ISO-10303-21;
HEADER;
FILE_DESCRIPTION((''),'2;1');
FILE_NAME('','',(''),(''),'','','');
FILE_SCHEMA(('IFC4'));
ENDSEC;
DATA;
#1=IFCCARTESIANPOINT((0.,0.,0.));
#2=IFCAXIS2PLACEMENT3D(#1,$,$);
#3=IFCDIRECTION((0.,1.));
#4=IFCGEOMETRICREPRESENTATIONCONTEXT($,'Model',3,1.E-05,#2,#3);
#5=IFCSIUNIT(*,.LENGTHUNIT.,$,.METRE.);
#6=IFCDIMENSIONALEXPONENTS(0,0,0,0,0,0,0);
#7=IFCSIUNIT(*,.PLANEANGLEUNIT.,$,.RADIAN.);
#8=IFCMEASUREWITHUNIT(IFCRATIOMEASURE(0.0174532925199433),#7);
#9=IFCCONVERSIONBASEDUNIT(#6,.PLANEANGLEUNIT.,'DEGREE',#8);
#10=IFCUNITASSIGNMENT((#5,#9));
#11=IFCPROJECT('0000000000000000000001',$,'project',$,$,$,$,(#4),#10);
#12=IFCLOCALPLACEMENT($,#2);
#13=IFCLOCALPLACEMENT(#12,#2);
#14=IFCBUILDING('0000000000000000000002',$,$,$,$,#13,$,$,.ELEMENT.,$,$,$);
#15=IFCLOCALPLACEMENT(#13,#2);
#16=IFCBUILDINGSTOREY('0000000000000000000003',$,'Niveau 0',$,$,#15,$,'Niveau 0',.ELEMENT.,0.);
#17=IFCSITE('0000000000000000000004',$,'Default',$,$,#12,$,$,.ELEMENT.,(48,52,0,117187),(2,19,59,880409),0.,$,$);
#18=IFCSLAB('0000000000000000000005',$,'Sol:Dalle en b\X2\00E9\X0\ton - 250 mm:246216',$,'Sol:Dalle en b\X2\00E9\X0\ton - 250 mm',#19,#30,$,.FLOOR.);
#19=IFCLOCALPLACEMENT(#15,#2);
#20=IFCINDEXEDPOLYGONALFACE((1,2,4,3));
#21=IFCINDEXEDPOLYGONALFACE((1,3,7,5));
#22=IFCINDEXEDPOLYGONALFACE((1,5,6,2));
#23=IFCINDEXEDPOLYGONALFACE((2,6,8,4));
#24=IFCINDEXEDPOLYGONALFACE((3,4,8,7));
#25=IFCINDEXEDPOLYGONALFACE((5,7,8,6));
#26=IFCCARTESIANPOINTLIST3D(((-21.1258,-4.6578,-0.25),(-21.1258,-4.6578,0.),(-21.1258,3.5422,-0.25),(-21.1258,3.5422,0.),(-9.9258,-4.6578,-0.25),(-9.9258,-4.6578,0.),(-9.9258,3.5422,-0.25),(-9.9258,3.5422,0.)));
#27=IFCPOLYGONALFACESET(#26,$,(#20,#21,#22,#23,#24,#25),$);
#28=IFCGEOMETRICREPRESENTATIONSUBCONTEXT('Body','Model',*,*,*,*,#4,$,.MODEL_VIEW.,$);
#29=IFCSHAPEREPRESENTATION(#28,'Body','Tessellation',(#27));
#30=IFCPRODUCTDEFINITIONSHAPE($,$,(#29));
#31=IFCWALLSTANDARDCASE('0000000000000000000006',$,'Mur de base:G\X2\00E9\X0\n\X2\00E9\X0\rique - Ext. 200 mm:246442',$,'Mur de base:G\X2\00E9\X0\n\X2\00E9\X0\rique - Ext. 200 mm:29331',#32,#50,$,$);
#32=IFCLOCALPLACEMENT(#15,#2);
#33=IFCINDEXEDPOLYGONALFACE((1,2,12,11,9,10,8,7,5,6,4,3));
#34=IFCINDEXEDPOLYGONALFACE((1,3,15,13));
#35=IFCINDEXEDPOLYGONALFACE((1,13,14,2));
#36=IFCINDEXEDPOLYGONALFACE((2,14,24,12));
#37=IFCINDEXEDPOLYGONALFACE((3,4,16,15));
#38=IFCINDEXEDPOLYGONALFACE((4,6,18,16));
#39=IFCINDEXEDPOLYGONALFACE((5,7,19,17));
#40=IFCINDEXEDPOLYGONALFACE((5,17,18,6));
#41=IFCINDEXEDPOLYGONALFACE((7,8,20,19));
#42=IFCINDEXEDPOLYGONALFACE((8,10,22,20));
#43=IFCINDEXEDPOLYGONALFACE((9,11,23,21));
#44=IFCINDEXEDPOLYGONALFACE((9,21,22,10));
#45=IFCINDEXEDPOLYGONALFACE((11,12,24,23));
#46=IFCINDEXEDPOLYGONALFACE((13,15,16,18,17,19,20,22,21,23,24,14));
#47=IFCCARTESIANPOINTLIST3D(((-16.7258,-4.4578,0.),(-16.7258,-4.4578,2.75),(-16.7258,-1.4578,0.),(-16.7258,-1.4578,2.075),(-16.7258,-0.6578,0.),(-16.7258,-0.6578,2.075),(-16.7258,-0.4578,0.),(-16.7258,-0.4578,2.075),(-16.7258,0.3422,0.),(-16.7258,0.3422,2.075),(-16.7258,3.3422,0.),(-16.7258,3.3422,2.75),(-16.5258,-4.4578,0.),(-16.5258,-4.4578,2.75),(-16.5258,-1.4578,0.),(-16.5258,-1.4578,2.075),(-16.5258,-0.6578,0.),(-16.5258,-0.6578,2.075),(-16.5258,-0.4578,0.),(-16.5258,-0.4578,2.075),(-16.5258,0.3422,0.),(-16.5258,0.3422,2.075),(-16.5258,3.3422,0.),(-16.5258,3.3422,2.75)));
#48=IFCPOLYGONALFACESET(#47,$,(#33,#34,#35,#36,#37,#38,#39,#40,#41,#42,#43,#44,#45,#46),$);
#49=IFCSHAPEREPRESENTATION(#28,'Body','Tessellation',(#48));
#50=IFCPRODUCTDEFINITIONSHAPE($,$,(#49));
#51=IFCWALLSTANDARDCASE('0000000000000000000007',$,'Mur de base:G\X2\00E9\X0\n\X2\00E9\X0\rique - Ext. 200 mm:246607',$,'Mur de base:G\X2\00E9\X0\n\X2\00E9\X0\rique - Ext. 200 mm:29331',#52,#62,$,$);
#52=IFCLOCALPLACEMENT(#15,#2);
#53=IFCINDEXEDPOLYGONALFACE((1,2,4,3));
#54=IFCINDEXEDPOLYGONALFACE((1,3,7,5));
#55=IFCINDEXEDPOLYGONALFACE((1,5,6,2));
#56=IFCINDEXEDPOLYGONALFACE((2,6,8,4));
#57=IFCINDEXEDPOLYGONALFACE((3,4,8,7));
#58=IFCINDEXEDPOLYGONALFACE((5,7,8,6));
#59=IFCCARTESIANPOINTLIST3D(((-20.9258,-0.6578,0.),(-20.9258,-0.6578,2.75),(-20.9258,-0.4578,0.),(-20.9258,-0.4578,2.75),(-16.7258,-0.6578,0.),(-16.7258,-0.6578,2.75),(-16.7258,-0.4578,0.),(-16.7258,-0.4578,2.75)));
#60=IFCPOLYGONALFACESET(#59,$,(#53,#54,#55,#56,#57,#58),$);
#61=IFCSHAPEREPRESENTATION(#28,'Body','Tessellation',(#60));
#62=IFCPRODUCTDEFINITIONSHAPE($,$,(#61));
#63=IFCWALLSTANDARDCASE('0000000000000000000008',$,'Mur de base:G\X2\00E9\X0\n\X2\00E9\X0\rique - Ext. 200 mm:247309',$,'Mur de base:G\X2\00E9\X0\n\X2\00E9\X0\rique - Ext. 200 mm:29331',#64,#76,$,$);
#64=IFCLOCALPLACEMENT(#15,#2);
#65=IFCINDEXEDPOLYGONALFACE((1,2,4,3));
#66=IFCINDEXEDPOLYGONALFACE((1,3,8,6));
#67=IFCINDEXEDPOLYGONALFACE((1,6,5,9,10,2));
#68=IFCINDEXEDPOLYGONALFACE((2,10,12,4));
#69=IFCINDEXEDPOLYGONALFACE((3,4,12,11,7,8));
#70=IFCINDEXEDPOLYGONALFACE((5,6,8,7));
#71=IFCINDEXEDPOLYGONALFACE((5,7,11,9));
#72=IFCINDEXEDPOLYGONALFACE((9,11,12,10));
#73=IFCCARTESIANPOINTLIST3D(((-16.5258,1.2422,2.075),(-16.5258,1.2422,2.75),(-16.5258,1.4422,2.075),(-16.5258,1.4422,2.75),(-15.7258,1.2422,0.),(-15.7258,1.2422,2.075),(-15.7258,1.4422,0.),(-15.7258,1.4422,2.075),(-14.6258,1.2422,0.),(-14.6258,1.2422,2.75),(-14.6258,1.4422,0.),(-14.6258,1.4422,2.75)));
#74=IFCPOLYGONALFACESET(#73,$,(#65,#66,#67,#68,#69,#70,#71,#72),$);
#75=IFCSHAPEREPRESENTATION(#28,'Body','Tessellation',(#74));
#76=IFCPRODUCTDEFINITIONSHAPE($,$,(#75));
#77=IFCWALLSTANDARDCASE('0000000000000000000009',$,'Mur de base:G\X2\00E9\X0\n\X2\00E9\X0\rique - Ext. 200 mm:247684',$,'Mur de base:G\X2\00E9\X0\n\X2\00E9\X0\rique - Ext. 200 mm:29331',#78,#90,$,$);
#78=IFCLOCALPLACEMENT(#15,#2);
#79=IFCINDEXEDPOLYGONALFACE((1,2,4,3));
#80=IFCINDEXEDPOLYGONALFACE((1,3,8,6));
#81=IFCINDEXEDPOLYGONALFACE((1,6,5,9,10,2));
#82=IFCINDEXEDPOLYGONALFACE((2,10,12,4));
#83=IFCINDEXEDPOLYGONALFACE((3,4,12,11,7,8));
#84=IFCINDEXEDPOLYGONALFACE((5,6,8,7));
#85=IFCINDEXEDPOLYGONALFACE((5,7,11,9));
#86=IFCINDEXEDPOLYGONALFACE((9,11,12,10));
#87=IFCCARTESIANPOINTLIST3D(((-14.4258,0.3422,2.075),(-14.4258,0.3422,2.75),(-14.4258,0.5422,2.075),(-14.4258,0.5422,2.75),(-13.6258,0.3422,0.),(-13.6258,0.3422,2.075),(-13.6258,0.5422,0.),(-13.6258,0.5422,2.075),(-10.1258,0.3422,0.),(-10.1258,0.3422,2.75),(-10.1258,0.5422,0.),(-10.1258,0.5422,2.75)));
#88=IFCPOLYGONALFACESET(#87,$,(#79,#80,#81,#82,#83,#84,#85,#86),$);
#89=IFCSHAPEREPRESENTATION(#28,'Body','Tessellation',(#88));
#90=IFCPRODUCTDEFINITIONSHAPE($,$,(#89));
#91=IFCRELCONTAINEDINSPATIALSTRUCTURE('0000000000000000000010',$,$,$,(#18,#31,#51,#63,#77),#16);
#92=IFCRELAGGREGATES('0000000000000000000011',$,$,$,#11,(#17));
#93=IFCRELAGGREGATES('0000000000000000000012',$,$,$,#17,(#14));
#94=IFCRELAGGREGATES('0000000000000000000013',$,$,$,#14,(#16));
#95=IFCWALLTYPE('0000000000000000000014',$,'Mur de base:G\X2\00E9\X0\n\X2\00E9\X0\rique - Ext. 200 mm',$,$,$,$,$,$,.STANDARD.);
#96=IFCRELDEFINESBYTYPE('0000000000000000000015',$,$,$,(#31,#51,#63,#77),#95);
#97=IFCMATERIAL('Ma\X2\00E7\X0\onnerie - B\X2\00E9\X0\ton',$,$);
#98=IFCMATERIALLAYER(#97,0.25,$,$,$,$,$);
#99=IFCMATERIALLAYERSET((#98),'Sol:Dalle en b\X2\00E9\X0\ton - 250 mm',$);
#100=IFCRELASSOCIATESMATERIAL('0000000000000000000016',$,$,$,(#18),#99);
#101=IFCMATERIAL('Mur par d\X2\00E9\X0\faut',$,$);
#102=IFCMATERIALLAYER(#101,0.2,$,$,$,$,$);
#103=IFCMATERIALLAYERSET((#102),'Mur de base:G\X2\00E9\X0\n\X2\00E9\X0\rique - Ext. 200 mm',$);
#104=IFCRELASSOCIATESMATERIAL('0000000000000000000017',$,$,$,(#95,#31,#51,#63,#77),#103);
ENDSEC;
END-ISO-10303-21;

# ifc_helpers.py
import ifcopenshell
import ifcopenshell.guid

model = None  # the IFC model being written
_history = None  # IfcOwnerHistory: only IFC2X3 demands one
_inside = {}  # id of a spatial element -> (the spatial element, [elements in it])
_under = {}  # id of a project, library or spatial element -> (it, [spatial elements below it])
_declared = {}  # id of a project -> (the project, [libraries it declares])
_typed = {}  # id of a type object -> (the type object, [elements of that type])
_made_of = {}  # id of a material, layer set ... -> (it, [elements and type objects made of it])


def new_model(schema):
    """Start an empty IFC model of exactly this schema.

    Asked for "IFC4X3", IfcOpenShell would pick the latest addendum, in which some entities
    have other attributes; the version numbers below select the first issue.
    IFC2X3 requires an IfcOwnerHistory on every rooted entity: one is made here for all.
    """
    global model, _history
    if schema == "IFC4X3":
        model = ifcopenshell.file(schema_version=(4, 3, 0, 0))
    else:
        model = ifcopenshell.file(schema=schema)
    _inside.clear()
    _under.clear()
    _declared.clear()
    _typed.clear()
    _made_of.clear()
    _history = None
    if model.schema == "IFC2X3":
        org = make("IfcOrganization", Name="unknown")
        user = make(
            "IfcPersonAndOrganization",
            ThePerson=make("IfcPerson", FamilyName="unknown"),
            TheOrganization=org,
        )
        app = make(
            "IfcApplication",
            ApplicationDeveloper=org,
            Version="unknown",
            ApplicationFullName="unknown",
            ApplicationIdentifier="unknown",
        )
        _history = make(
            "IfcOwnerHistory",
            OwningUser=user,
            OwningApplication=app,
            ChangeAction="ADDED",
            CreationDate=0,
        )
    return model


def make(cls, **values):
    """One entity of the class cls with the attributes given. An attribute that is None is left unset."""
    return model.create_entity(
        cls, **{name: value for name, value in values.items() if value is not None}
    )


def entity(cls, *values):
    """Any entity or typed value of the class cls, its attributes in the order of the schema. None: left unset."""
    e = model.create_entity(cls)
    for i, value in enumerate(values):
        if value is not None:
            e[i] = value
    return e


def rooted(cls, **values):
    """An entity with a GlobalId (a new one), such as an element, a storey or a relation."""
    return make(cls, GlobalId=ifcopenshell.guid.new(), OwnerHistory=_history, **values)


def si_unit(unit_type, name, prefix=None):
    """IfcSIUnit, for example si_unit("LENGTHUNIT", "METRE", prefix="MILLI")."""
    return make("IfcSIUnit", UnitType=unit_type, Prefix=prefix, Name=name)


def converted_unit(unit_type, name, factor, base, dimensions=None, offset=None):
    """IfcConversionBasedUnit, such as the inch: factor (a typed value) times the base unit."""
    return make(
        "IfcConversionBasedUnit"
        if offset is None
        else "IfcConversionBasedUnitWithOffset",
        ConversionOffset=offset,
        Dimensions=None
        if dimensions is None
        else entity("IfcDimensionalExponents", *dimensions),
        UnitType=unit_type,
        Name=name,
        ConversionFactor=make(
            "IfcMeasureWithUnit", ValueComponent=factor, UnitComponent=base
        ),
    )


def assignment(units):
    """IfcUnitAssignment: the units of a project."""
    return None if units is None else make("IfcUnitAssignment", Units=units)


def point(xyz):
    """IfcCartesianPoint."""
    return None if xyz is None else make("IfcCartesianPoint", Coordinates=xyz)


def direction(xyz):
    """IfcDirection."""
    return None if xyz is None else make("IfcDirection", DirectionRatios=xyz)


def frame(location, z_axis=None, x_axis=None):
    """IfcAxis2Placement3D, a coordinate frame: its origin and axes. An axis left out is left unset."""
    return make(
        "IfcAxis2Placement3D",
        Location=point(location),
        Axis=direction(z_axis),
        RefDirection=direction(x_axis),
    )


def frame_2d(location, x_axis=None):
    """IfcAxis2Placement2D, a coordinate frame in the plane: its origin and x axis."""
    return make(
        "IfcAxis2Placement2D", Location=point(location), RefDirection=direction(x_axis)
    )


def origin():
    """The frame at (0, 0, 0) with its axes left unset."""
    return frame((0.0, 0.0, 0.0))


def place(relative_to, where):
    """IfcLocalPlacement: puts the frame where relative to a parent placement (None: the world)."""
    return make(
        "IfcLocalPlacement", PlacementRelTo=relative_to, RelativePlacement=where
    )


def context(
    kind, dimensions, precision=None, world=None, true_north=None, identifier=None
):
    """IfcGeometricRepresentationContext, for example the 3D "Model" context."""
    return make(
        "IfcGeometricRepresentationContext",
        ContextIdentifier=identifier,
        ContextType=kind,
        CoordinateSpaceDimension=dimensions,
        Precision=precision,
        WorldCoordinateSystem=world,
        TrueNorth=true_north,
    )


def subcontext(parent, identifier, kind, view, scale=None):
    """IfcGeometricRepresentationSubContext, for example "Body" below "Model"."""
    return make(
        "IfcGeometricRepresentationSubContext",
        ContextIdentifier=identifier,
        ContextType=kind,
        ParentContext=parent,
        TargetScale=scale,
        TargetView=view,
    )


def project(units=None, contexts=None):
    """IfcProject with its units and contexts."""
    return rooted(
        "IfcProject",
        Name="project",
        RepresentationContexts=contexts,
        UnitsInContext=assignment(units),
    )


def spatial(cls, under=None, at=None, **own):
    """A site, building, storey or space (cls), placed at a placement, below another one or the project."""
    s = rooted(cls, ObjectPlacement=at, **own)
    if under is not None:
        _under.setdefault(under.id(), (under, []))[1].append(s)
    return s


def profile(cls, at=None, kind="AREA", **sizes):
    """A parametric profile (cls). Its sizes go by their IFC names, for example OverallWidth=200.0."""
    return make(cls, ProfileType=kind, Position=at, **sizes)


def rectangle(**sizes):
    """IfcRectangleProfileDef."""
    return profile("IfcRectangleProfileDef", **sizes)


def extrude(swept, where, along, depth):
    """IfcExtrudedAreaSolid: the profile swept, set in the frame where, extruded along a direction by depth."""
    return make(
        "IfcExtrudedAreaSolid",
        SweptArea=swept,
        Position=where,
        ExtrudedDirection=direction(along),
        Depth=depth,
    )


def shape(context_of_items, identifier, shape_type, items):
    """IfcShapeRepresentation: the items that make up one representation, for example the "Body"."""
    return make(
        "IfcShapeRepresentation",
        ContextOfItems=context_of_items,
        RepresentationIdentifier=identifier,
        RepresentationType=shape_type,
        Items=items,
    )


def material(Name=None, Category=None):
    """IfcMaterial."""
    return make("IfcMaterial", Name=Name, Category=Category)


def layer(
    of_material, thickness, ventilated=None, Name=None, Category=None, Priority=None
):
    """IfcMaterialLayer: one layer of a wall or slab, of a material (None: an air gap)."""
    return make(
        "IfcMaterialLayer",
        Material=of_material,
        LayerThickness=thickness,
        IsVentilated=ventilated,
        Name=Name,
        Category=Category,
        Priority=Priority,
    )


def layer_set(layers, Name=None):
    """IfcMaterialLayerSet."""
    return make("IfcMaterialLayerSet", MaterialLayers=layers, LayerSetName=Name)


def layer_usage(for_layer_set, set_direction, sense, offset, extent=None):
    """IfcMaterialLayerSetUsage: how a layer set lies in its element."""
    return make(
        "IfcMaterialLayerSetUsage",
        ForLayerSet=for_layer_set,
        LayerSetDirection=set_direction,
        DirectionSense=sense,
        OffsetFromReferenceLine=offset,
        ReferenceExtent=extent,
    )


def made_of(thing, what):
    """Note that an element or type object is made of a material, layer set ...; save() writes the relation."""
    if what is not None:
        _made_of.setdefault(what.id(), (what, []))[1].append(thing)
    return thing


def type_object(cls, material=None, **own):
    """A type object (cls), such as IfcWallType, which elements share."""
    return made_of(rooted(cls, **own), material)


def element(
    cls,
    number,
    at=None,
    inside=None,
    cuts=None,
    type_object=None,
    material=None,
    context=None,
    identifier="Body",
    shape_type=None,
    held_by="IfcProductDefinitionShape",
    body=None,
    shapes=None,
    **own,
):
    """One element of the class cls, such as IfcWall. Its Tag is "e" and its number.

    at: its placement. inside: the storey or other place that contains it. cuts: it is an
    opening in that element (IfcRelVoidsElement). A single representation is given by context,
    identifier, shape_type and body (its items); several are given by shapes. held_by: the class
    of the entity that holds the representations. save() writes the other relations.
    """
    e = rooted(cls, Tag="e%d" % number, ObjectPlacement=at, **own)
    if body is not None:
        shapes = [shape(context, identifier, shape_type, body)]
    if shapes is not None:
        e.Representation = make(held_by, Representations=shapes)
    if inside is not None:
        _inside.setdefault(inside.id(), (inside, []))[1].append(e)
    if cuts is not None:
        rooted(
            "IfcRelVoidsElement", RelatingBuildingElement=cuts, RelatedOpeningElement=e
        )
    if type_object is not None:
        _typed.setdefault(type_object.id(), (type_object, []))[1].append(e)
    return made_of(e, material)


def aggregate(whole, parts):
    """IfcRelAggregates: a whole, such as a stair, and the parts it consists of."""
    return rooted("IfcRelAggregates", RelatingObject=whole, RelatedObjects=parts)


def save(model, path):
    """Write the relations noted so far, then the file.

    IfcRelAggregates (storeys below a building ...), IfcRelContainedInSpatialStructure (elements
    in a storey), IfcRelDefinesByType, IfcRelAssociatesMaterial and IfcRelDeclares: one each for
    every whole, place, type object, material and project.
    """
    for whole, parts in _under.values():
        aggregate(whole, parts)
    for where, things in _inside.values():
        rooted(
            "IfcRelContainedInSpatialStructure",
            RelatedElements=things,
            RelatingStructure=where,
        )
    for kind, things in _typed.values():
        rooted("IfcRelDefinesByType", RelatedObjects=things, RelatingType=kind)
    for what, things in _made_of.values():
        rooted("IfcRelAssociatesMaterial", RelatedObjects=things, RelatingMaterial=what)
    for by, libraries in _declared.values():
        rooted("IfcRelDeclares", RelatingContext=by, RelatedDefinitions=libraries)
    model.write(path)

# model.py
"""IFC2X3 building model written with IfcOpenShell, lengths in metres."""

from ifc_helpers import new_model, entity, si_unit, converted_unit, direction, frame, frame_2d, origin, place, context, subcontext, project, spatial, rectangle, extrude, material, layer, layer_set, layer_usage, type_object, element, save


model = new_model("IFC2X3")

# Units and contexts
model_context = context("Model", 3, precision=1e-05, world=origin(), true_north=direction((0.0, 1.0)))
body_context = subcontext(model_context, "Body", "Model", "MODEL_VIEW")
ifc_project = project(units=[si_unit("LENGTHUNIT", "METRE"), converted_unit("PLANEANGLEUNIT", "DEGREE", entity("IfcRatioMeasure", 0.0174532925199433), si_unit("PLANEANGLEUNIT", "RADIAN"), dimensions=[0, 0, 0, 0, 0, 0, 0])], contexts=[model_context])

# Site, building, storey
site_placement = place(None, origin())
site = spatial("IfcSite", under=ifc_project, at=site_placement, Name="Default", CompositionType="ELEMENT", RefLatitude=(48, 52, 0, 117187), RefLongitude=(2, 19, 59, 880409), RefElevation=0.0)
building_placement = place(site_placement, origin())
building = spatial("IfcBuilding", under=site, at=building_placement, CompositionType="ELEMENT")
storey_placement = place(building_placement, origin())
storey = spatial("IfcBuildingStorey", under=building, at=storey_placement, Name="Niveau 0", LongName="Niveau 0", CompositionType="ELEMENT", Elevation=0.0)

# Slab
ifc_material_1 = material(Name="Maçonnerie - Béton")
ifc_layer_1 = layer(ifc_material_1, 0.25)
ifc_layer_set_1 = layer_set([ifc_layer_1], Name="Sol:Dalle en béton - 250 mm")
ifc_layer_usage_1 = layer_usage(ifc_layer_set_1, "AXIS3", "POSITIVE", 0.0)
slab_placement = place(storey_placement, origin())
element("IfcSlab", 1, at=slab_placement, inside=storey, material=ifc_layer_usage_1, Name="Sol:Dalle en béton - 250 mm:246216", ObjectType="Sol:Dalle en béton - 250 mm", PredefinedType="FLOOR", context=body_context, shape_type="SweptSolid", body=[
    extrude(rectangle(XDim=8.2, YDim=11.2, at=frame_2d((0.0, 0.0), x_axis=(1.0, 0.0))), frame((-15.5258, -0.5578, 0.0), z_axis=(0.0, 0.0, -1.0), x_axis=(0.0, 1.0, 0.0)), (0.0, 0.0, 1.0), 0.25),
])

# Wall, openings
ifc_material_2 = material(Name="Mur par défaut")
ifc_layer_2 = layer(ifc_material_2, 0.2)
ifc_layer_set_2 = layer_set([ifc_layer_2], Name="Mur de base:Générique - Ext. 200 mm")
ifc_layer_usage_2 = layer_usage(ifc_layer_set_2, "AXIS2", "NEGATIVE", 0.1)
wall_type = type_object("IfcWallType", Name="Mur de base:Générique - Ext. 200 mm", PredefinedType="STANDARD", material=ifc_layer_set_2)
wall_1_placement = place(storey_placement, frame((-16.6258, -4.4578, 0.0), z_axis=(0.0, 0.0, 1.0), x_axis=(0.0, 1.0, 0.0)))
wall_1 = element("IfcWallStandardCase", 2, at=wall_1_placement, inside=storey, type_object=wall_type, material=ifc_layer_usage_2, Name="Mur de base:Générique - Ext. 200 mm:246442", ObjectType="Mur de base:Générique - Ext. 200 mm:29331", context=body_context, shape_type="SweptSolid", body=[
    extrude(rectangle(XDim=7.8, YDim=0.2, at=frame_2d((3.9, 0.0), x_axis=(-1.0, 0.0))), origin(), (0.0, 0.0, 1.0), 2.75),
])
opening_1_placement = place(wall_1_placement, origin())
element("IfcOpeningElement", 3, at=opening_1_placement, cuts=wall_1, ObjectType="Opening", context=body_context, shape_type="SweptSolid", body=[
    extrude(rectangle(XDim=2.075, YDim=0.2, at=frame_2d((0.0, 0.0), x_axis=(0.0, 1.0))), frame((5.8, -0.9, 1.0375), z_axis=(0.0, 1.0, 0.0), x_axis=(-1.0, 0.0, 0.0)), (0.0, 0.0, 1.0), 0.8),
])
opening_2_placement = place(wall_1_placement, frame((3.0, -0.1, 0.0)))
element("IfcOpeningElement", 4, at=opening_2_placement, cuts=wall_1, ObjectType="Opening", context=body_context, shape_type="SweptSolid", body=[
    extrude(rectangle(XDim=2.075, YDim=0.8, at=frame_2d((1.0375, 0.4), x_axis=(1.0, 0.0))), frame((0.0, 0.0, 0.0), z_axis=(0.0, 1.0, 0.0), x_axis=(0.0, 0.0, 1.0)), (0.0, 0.0, 1.0), 0.2),
])
opening_3_placement = place(wall_1_placement, frame((4.0, -0.1, 0.0)))
element("IfcOpeningElement", 5, at=opening_3_placement, cuts=wall_1, ObjectType="Opening", context=body_context, shape_type="SweptSolid", body=[
    extrude(rectangle(XDim=2.075, YDim=0.8, at=frame_2d((1.0375, 0.4), x_axis=(1.0, 0.0))), frame((0.0, 0.0, 0.0), z_axis=(0.0, 1.0, 0.0), x_axis=(0.0, 0.0, 1.0)), (0.0, 0.0, 1.0), 0.2),
])

# Wall
ifc_layer_usage_3 = layer_usage(ifc_layer_set_2, "AXIS2", "NEGATIVE", 0.1)
wall_2_placement = place(storey_placement, frame((-16.7258, -0.5578, 0.0), z_axis=(0.0, 0.0, 1.0), x_axis=(-1.0, 0.0, 0.0)))
element("IfcWallStandardCase", 6, at=wall_2_placement, inside=storey, type_object=wall_type, material=ifc_layer_usage_3, Name="Mur de base:Générique - Ext. 200 mm:246607", ObjectType="Mur de base:Générique - Ext. 200 mm:29331", context=body_context, shape_type="SweptSolid", body=[
    extrude(rectangle(XDim=4.2, YDim=0.2, at=frame_2d((2.1, 0.0), x_axis=(-1.0, 0.0))), origin(), (0.0, 0.0, 1.0), 2.75),
])

# Walls, openings
ifc_layer_usage_4 = layer_usage(ifc_layer_set_2, "AXIS2", "NEGATIVE", 0.1)
wall_3_placement = place(storey_placement, frame((-16.5258, 1.3422, 0.0)))
wall_3 = element("IfcWallStandardCase", 7, at=wall_3_placement, inside=storey, type_object=wall_type, material=ifc_layer_usage_4, Name="Mur de base:Générique - Ext. 200 mm:247309", ObjectType="Mur de base:Générique - Ext. 200 mm:29331", context=body_context, shape_type="SweptSolid", body=[
    extrude(rectangle(XDim=1.9, YDim=0.2, at=frame_2d((0.95, 0.0), x_axis=(-1.0, 0.0))), origin(), (0.0, 0.0, 1.0), 2.75),
])
opening_4_placement = place(wall_3_placement, frame((0.0, -0.1, 0.0)))
element("IfcOpeningElement", 8, at=opening_4_placement, cuts=wall_3, ObjectType="Opening", context=body_context, shape_type="SweptSolid", body=[
    extrude(rectangle(XDim=2.075, YDim=0.8, at=frame_2d((1.0375, 0.4), x_axis=(1.0, 0.0))), frame((0.0, 0.0, 0.0), z_axis=(0.0, 1.0, 0.0), x_axis=(0.0, 0.0, 1.0)), (0.0, 0.0, 1.0), 0.2),
])
ifc_layer_usage_5 = layer_usage(ifc_layer_set_2, "AXIS2", "NEGATIVE", 0.1)
wall_4_placement = place(storey_placement, frame((-14.4258, 0.4422, 0.0)))
wall_4 = element("IfcWallStandardCase", 9, at=wall_4_placement, inside=storey, type_object=wall_type, material=ifc_layer_usage_5, Name="Mur de base:Générique - Ext. 200 mm:247684", ObjectType="Mur de base:Générique - Ext. 200 mm:29331", context=body_context, shape_type="SweptSolid", body=[
    extrude(rectangle(XDim=4.3, YDim=0.2, at=frame_2d((2.15, 0.0), x_axis=(-1.0, 0.0))), origin(), (0.0, 0.0, 1.0), 2.75),
])
opening_5_placement = place(wall_4_placement, frame((0.0, -0.1, 0.0)))
element("IfcOpeningElement", 10, at=opening_5_placement, cuts=wall_4, ObjectType="Opening", context=body_context, shape_type="SweptSolid", body=[
    extrude(rectangle(XDim=2.075, YDim=0.8, at=frame_2d((1.0375, 0.4), x_axis=(1.0, 0.0))), frame((0.0, 0.0, 0.0), z_axis=(0.0, 1.0, 0.0), x_axis=(0.0, 0.0, 1.0)), (0.0, 0.0, 1.0), 0.2),
])

save(model, "model.ifc")
